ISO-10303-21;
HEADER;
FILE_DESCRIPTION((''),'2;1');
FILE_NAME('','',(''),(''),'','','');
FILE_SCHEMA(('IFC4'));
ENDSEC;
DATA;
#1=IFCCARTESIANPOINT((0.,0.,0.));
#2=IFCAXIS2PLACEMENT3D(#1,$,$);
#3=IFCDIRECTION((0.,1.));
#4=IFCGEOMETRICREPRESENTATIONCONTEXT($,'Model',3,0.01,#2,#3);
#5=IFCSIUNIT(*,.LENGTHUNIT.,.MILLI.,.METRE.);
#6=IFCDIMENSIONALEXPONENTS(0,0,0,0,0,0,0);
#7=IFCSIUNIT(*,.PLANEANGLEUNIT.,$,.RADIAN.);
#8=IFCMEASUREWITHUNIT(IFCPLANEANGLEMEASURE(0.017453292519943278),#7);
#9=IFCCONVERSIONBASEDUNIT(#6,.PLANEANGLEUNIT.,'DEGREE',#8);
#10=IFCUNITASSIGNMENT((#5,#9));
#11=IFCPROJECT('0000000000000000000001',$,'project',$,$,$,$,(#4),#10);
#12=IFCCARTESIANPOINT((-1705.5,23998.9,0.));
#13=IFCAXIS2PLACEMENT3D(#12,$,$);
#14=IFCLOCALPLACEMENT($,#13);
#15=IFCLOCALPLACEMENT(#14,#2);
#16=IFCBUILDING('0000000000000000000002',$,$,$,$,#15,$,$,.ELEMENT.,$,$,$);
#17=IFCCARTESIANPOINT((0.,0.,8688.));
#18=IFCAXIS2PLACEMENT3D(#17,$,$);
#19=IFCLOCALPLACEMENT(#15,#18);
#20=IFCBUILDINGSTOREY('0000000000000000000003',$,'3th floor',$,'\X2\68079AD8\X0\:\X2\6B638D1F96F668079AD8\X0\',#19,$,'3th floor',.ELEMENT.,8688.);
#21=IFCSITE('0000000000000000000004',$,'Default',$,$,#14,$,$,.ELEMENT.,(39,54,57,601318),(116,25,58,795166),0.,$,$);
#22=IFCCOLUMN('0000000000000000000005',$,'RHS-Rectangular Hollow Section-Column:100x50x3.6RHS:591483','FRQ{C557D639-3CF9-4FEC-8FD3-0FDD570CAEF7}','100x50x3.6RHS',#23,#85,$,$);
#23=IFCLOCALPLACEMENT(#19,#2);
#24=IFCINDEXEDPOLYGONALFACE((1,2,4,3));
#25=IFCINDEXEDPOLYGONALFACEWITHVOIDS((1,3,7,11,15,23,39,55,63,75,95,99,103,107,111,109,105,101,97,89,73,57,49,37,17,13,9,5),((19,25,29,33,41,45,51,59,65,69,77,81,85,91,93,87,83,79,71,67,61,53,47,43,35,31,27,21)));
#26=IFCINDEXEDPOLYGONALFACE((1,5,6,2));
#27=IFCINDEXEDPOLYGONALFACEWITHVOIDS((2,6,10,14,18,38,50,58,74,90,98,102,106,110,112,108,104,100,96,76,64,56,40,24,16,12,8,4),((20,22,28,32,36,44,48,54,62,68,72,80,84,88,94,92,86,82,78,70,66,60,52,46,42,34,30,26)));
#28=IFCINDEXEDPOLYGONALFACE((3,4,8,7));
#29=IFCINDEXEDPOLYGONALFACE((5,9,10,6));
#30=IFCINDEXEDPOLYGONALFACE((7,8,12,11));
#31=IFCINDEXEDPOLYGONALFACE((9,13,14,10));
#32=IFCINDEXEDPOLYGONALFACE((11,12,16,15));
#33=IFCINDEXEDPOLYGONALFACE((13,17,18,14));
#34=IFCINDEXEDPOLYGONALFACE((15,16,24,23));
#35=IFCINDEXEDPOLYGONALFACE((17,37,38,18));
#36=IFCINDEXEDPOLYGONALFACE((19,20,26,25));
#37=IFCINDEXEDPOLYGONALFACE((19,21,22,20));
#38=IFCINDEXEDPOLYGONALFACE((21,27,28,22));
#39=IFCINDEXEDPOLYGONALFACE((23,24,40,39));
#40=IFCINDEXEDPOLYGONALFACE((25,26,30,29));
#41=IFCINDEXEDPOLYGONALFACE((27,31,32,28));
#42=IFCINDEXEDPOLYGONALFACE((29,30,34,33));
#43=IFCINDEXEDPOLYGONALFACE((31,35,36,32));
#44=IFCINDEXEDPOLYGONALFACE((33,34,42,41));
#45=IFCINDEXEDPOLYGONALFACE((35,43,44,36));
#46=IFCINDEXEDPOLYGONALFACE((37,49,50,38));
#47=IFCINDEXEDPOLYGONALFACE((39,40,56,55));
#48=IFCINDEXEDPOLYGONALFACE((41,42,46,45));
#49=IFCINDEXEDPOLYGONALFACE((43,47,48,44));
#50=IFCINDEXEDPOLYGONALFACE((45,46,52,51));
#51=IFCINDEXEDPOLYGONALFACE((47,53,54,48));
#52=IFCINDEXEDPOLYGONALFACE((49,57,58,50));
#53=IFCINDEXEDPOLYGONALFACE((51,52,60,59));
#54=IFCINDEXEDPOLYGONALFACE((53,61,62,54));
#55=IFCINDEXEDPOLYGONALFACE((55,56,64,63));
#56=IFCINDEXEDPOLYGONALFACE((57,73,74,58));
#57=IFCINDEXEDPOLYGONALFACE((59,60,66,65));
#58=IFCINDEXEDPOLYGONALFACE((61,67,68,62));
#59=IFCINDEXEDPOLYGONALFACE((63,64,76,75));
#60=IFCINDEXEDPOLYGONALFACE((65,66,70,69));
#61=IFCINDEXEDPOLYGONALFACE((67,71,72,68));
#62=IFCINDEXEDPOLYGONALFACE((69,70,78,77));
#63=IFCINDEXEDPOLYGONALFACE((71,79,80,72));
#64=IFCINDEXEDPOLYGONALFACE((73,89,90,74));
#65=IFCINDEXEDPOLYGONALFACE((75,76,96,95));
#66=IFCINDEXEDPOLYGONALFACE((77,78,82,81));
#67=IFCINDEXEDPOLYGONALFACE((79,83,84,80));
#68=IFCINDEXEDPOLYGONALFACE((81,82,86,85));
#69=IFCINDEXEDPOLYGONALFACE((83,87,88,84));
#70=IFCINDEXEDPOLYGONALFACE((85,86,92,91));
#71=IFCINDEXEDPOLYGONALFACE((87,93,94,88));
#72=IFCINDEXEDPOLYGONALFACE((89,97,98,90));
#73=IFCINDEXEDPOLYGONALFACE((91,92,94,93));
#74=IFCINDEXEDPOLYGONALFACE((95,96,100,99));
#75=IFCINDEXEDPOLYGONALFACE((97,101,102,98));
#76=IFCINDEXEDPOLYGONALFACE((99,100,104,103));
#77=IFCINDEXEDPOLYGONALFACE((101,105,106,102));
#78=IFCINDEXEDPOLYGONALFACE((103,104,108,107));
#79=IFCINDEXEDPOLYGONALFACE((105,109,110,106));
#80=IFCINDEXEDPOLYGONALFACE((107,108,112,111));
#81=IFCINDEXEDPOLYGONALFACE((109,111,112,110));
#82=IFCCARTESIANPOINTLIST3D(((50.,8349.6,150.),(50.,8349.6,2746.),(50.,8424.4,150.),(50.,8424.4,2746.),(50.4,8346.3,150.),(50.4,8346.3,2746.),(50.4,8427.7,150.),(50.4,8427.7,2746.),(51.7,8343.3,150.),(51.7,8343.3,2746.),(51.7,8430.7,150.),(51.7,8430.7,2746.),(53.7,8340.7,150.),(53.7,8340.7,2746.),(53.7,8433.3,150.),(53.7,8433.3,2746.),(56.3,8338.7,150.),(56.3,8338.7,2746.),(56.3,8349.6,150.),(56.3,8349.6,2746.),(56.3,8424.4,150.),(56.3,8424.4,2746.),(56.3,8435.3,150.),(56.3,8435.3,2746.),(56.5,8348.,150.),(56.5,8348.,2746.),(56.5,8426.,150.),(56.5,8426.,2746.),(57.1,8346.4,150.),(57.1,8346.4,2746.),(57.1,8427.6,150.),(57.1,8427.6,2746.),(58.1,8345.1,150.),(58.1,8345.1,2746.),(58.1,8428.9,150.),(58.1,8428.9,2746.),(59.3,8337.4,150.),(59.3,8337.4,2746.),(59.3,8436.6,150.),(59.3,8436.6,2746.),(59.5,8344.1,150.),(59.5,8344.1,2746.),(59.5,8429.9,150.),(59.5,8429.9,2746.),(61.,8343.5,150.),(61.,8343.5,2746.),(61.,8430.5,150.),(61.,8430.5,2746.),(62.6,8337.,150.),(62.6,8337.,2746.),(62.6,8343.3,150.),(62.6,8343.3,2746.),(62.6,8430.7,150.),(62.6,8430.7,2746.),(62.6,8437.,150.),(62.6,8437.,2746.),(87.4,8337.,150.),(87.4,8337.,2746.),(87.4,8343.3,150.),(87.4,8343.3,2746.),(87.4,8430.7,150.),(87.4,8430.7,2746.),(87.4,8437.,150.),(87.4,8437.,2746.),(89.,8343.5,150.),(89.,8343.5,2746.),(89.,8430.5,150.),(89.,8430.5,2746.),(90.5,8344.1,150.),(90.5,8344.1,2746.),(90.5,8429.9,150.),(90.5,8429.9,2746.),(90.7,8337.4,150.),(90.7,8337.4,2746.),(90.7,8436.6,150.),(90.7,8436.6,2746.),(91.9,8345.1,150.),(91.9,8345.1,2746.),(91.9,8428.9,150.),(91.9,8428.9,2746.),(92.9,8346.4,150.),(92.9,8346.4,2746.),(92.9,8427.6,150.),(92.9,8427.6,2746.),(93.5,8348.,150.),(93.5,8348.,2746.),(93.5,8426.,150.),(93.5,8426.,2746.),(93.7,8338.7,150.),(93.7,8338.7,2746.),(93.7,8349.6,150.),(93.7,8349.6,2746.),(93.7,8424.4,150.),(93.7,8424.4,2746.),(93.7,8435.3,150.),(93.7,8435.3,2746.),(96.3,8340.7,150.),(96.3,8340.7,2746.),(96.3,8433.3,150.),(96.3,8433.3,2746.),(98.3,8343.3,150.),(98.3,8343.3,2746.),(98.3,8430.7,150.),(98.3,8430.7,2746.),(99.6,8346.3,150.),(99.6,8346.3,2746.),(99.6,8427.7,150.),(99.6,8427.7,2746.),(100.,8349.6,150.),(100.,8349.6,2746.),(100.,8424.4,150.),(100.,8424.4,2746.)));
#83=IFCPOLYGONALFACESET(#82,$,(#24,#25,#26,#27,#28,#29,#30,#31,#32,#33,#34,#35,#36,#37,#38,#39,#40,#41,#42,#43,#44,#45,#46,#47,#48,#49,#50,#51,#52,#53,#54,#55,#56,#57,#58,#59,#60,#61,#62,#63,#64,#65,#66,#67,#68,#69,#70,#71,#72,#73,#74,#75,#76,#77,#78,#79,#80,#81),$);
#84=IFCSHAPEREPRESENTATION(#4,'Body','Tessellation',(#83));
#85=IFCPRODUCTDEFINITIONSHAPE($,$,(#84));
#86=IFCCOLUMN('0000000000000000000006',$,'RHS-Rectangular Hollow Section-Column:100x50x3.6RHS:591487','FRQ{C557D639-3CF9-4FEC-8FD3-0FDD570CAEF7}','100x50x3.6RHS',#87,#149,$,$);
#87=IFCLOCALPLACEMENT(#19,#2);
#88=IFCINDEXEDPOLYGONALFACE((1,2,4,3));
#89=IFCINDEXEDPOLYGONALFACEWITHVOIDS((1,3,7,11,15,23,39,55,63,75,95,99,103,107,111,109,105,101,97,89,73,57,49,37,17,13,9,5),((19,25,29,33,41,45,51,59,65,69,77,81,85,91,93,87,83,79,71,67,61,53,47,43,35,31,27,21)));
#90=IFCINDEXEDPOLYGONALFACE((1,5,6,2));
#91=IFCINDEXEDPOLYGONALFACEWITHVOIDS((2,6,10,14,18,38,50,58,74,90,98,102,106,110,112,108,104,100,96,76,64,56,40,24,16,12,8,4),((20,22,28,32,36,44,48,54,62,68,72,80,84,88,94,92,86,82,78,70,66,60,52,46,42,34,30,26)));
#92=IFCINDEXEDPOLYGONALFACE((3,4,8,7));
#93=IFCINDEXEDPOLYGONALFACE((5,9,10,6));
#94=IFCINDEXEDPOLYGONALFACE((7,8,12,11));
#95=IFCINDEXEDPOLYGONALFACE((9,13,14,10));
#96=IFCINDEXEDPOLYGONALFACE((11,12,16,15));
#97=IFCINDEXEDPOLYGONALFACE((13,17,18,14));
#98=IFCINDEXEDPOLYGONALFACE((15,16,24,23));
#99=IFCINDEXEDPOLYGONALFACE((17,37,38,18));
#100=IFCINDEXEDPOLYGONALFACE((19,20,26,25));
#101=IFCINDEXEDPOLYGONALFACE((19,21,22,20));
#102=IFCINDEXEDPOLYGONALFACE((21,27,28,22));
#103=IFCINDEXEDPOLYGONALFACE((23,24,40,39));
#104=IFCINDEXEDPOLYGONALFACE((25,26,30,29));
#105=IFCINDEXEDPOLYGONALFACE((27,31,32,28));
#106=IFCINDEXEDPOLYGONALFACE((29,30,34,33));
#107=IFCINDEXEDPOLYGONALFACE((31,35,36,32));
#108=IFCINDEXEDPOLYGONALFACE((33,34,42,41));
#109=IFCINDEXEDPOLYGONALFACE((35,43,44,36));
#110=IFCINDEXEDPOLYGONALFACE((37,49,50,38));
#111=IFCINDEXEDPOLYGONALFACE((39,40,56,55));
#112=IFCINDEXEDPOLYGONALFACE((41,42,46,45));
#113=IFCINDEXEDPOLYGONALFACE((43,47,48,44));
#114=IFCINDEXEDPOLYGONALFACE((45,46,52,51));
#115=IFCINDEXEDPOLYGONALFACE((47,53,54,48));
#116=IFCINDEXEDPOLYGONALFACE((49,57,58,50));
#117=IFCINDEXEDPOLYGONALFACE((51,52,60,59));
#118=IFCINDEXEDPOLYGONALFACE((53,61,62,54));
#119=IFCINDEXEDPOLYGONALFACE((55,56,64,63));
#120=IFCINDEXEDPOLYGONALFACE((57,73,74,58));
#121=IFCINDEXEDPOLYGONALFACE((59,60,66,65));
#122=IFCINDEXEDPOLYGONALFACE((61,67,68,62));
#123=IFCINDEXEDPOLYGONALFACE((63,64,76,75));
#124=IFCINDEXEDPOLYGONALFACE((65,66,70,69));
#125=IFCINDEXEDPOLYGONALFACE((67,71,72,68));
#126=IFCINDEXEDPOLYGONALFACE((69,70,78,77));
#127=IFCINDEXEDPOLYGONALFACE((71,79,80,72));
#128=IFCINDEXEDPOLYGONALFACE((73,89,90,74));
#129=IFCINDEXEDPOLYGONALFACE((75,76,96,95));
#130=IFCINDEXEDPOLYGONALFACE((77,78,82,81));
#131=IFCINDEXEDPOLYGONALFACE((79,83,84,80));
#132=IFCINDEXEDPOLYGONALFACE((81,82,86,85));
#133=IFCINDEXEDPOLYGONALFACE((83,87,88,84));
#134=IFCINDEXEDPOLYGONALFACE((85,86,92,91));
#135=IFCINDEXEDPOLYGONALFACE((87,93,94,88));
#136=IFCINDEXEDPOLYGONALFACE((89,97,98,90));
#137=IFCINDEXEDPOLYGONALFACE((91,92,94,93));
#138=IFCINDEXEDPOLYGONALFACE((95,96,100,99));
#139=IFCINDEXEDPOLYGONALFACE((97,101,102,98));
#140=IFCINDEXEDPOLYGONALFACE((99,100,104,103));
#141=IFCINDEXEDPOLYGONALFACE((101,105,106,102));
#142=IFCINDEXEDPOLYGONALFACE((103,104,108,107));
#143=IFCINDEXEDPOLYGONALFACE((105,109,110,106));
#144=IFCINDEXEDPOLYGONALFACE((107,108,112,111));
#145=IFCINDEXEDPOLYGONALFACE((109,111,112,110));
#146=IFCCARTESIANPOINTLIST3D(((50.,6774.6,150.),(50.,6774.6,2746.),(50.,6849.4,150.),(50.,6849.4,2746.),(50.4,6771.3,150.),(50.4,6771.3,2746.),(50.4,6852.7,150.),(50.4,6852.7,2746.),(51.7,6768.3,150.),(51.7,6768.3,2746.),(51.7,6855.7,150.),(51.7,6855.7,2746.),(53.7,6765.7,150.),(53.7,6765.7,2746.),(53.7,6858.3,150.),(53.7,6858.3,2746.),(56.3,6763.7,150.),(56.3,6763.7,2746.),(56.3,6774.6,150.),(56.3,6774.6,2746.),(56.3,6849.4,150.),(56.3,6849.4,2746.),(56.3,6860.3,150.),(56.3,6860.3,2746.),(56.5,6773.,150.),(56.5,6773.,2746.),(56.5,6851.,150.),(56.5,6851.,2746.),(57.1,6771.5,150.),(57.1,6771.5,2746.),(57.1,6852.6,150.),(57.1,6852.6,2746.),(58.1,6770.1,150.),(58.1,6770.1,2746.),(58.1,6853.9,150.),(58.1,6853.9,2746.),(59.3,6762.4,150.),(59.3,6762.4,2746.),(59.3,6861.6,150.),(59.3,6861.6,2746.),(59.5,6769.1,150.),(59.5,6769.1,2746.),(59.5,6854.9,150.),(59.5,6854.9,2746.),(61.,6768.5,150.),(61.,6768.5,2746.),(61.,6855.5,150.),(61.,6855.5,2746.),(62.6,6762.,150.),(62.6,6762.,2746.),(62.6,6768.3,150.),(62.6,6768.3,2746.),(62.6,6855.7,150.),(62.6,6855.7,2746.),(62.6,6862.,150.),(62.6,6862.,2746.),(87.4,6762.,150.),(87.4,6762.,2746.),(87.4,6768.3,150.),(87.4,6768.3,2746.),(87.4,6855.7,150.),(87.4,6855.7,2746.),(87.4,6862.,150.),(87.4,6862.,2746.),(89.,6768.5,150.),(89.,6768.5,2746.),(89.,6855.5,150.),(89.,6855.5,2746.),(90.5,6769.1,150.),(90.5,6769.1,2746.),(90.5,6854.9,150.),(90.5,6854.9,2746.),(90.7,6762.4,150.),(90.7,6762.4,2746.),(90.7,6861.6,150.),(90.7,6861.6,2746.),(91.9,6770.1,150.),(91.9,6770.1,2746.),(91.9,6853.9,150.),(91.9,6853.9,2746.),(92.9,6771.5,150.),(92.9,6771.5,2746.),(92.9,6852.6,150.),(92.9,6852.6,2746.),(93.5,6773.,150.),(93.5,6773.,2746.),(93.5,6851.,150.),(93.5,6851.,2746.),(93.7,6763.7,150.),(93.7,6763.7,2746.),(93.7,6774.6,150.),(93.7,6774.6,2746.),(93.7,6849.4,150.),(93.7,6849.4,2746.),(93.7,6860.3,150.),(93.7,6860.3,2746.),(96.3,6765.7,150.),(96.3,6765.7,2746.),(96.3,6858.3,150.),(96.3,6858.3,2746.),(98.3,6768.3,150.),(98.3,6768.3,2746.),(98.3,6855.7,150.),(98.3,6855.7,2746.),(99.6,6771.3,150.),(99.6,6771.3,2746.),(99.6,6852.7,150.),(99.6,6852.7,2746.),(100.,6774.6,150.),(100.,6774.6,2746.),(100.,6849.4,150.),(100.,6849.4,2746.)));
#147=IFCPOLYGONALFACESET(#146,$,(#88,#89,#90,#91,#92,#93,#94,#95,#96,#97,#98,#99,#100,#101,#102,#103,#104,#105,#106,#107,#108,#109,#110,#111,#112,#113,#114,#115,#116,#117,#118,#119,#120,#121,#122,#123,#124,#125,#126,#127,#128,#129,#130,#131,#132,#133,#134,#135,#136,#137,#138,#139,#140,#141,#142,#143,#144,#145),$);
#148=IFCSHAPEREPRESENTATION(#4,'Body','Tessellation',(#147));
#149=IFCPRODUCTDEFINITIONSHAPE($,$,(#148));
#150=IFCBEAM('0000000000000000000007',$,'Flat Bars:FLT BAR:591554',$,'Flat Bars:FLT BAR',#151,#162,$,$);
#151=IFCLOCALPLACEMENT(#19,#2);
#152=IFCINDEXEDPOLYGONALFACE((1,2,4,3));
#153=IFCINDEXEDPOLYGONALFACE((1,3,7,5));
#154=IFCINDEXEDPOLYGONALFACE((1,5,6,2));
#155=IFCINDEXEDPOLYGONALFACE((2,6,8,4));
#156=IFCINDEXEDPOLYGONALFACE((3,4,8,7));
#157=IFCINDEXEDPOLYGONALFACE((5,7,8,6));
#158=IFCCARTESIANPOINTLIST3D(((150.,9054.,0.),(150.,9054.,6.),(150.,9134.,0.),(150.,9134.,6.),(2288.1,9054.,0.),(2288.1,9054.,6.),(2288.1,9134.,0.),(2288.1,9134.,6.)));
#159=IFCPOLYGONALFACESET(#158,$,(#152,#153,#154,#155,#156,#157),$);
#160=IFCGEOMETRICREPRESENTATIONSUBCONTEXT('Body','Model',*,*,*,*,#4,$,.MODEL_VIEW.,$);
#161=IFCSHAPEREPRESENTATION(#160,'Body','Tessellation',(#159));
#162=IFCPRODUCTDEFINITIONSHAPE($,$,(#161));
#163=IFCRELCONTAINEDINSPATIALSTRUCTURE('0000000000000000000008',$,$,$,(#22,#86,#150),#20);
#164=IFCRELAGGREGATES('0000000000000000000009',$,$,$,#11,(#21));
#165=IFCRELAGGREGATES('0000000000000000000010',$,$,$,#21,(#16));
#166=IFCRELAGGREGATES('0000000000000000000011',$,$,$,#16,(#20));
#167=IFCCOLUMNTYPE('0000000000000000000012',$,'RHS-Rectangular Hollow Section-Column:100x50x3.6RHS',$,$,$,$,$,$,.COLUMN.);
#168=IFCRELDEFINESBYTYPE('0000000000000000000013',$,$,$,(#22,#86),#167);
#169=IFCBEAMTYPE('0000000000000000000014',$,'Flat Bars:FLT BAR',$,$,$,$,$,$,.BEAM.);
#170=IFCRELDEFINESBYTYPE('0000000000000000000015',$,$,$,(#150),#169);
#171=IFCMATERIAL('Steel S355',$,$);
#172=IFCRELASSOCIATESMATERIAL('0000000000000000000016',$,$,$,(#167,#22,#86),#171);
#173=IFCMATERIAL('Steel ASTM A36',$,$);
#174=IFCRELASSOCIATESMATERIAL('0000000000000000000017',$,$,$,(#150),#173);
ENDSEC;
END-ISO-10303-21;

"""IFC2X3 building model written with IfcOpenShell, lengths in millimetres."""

from ifc_helpers import new_model, entity, si_unit, converted_unit, point, direction, frame, frame_2d, origin, origin_2d, origin_2d_with_axis, place, context, subcontext, project, spatial, circle_curve, line_curve, trimmed, segment, composite_curve, rectangle, hollow_rectangle, outline, extrude, clip, halfspace, material, type_object, element, save


model = new_model("IFC2X3")

# Units and contexts
model_context = context("Model", 3, precision=0.01, world=origin(), true_north=direction((0.0, 1.0)))
body_context = subcontext(model_context, "Body", "Model", "MODEL_VIEW")
ifc_project = project(units=[si_unit("LENGTHUNIT", "METRE", prefix="MILLI"), converted_unit("PLANEANGLEUNIT", "DEGREE", entity("IfcPlaneAngleMeasure", 0.017453292519943278), si_unit("PLANEANGLEUNIT", "RADIAN"), dimensions=[0, 0, 0, 0, 0, 0, 0])], contexts=[model_context])

# Site, building, storey
site_placement = place(None, frame((-1705.5, 23998.9, 0.0)))
site = spatial("IfcSite", under=ifc_project, at=site_placement, Name="Default", CompositionType="ELEMENT", RefLatitude=(39, 54, 57, 601318), RefLongitude=(116, 25, 58, 795166), RefElevation=0.0)
building_placement = place(site_placement, origin())
building = spatial("IfcBuilding", under=site, at=building_placement, CompositionType="ELEMENT")
storey_placement = place(building_placement, frame((0.0, 0.0, 8688.0)))
storey = spatial("IfcBuildingStorey", under=building, at=storey_placement, Name="3th floor", ObjectType="标高:正负零标高", LongName="3th floor", CompositionType="ELEMENT", Elevation=8688.0)

# Shared definitions
ifc_material_1 = material(Name="Steel S355")

# Columns, openings
column_type_1 = type_object("IfcColumnType", Name="RHS-Rectangular Hollow Section-Column:100x50x3.6RHS", PredefinedType="COLUMN", material=ifc_material_1)
column_1_placement = place(storey_placement, frame((75.0, 8387.0, 2876.9)))
column_1 = element("IfcColumn", 1, at=column_1_placement, inside=storey, type_object=column_type_1, material=ifc_material_1, Name="RHS-Rectangular Hollow Section-Column:100x50x3.6RHS:591483", Description="FRQ{C557D639-3CF9-4FEC-8FD3-0FDD570CAEF7}", ObjectType="100x50x3.6RHS", context=model_context, shape_type="Clipping", body=[
    clip(clip(extrude(hollow_rectangle(XDim=50.0, YDim=100.0, WallThickness=6.3, InnerFilletRadius=6.3, OuterFilletRadius=12.6, at=origin_2d()), origin(), (0.0, 0.0, -1.0), 2782.8), halfspace(frame((-75.0, -8387.0, -2726.9), z_axis=(0.0, 0.0, 1.0), x_axis=(1.0, 0.0, 0.0)), True)), halfspace(frame((-75.0, -8387.0, -55.9), z_axis=(0.0, 0.0, -1.0), x_axis=(-1.0, 0.0, 0.0)), True)),
])
opening_1_placement = place(column_1_placement, frame((0.0, -150.1, -130.9), z_axis=(0.0, 1.0, 0.0), x_axis=(-1.0, 0.0, 0.0)))
element("IfcOpeningElement", 2, at=opening_1_placement, cuts=column_1, ObjectType="Opening", context=model_context, shape_type="SweptSolid", body=[
    extrude(outline(composite_curve([segment(trimmed(circle_curve(frame_2d((43.0, 32.0), x_axis=(1.0, 0.0)), 32.0), [point((43.0, 0.0))], [point((75.0, 32.0))], True, "CARTESIAN"), True, "CONTINUOUS"), segment(trimmed(line_curve((75.0, 32.0), (0.0, 1.0), 86.0), [point((75.0, 32.0))], [point((75.0, 118.0))], True, "CARTESIAN"), True, "CONTINUOUS"), segment(trimmed(circle_curve(frame_2d((43.0, 118.0), x_axis=(1.0, 0.0)), 32.0), [point((75.0, 118.0))], [point((43.0, 150.0))], True, "CARTESIAN"), True, "CONTINUOUS"), segment(trimmed(line_curve((43.0, 150.0), (-1.0, 0.0), 86.0), [point((43.0, 150.0))], [point((-43.0, 150.0))], True, "CARTESIAN"), True, "CONTINUOUS"), segment(trimmed(circle_curve(frame_2d((-43.0, 118.0), x_axis=(1.0, 0.0)), 32.0), [point((-43.0, 150.0))], [point((-75.0, 118.0))], True, "CARTESIAN"), True, "CONTINUOUS"), segment(trimmed(line_curve((-75.0, 118.0), (0.0, -1.0), 86.0), [point((-75.0, 118.0))], [point((-75.0, 32.0))], True, "CARTESIAN"), True, "CONTINUOUS"), segment(trimmed(circle_curve(frame_2d((-43.0, 32.0), x_axis=(1.0, 0.0)), 32.0), [point((-75.0, 32.0))], [point((-43.0, 0.0))], True, "CARTESIAN"), True, "CONTINUOUS"), segment(trimmed(line_curve((-43.0, 0.0), (1.0, 0.0), 86.0), [point((-43.0, 0.0))], [point((43.0, 0.0))], True, "CARTESIAN"), True, "CONTINUOUS")], self_intersect="UNKNOWN")), origin(), (0.0, 0.0, 1.0), 300.2),
])
column_2_placement = place(storey_placement, frame((75.0, 6812.0, 2876.9)))
column_2 = element("IfcColumn", 3, at=column_2_placement, inside=storey, type_object=column_type_1, material=ifc_material_1, Name="RHS-Rectangular Hollow Section-Column:100x50x3.6RHS:591487", Description="FRQ{C557D639-3CF9-4FEC-8FD3-0FDD570CAEF7}", ObjectType="100x50x3.6RHS", context=model_context, shape_type="Clipping", body=[
    clip(clip(extrude(hollow_rectangle(XDim=50.0, YDim=100.0, WallThickness=6.3, InnerFilletRadius=6.3, OuterFilletRadius=12.6, at=origin_2d()), origin(), (0.0, 0.0, -1.0), 2782.8), halfspace(frame((-75.0, -6812.0, -2726.9), z_axis=(0.0, 0.0, 1.0), x_axis=(1.0, 0.0, 0.0)), True)), halfspace(frame((-75.0, -6812.0, -55.9), z_axis=(0.0, 0.0, -1.0), x_axis=(-1.0, 0.0, 0.0)), True)),
])
opening_2_placement = place(column_2_placement, frame((0.0, -150.1, -130.9), z_axis=(0.0, 1.0, 0.0), x_axis=(-1.0, 0.0, 0.0)))
element("IfcOpeningElement", 4, at=opening_2_placement, cuts=column_2, ObjectType="Opening", context=model_context, shape_type="SweptSolid", body=[
    extrude(outline(composite_curve([segment(trimmed(circle_curve(frame_2d((43.0, 32.0), x_axis=(1.0, 0.0)), 32.0), [point((43.0, 0.0))], [point((75.0, 32.0))], True, "CARTESIAN"), True, "CONTINUOUS"), segment(trimmed(line_curve((75.0, 32.0), (0.0, 1.0), 86.0), [point((75.0, 32.0))], [point((75.0, 118.0))], True, "CARTESIAN"), True, "CONTINUOUS"), segment(trimmed(circle_curve(frame_2d((43.0, 118.0), x_axis=(1.0, 0.0)), 32.0), [point((75.0, 118.0))], [point((43.0, 150.0))], True, "CARTESIAN"), True, "CONTINUOUS"), segment(trimmed(line_curve((43.0, 150.0), (-1.0, 0.0), 86.0), [point((43.0, 150.0))], [point((-43.0, 150.0))], True, "CARTESIAN"), True, "CONTINUOUS"), segment(trimmed(circle_curve(frame_2d((-43.0, 118.0), x_axis=(1.0, 0.0)), 32.0), [point((-43.0, 150.0))], [point((-75.0, 118.0))], True, "CARTESIAN"), True, "CONTINUOUS"), segment(trimmed(line_curve((-75.0, 118.0), (0.0, -1.0), 86.0), [point((-75.0, 118.0))], [point((-75.0, 32.0))], True, "CARTESIAN"), True, "CONTINUOUS"), segment(trimmed(circle_curve(frame_2d((-43.0, 32.0), x_axis=(1.0, 0.0)), 32.0), [point((-75.0, 32.0))], [point((-43.0, 0.0))], True, "CARTESIAN"), True, "CONTINUOUS"), segment(trimmed(line_curve((-43.0, 0.0), (1.0, 0.0), 86.0), [point((-43.0, 0.0))], [point((43.0, 0.0))], True, "CARTESIAN"), True, "CONTINUOUS")], self_intersect="UNKNOWN")), origin(), (0.0, 0.0, 1.0), 300.2),
])

# Beam
ifc_material_2 = material(Name="Steel ASTM A36")
beam_type = type_object("IfcBeamType", Name="Flat Bars:FLT BAR", PredefinedType="BEAM")
for number, where, name in (
    (5, (150.0, 9094.0, 6.0), "Flat Bars:FLT BAR:591554"),
):
    element("IfcBeam", number, at=place(storey_placement, frame(where)), inside=storey, type_object=beam_type, material=ifc_material_2, Name=name, ObjectType="Flat Bars:FLT BAR", context=body_context, shape_type="SweptSolid", body=[
        extrude(rectangle(XDim=6.0, YDim=80.0, at=origin_2d_with_axis()), frame((0.0, 0.0, -3.0), z_axis=(1.0, 0.0, 0.0), x_axis=(0.0, 0.0, -1.0)), (0.0, 0.0, 1.0), 2138.1),
    ])

save(model, "model.ifc")
